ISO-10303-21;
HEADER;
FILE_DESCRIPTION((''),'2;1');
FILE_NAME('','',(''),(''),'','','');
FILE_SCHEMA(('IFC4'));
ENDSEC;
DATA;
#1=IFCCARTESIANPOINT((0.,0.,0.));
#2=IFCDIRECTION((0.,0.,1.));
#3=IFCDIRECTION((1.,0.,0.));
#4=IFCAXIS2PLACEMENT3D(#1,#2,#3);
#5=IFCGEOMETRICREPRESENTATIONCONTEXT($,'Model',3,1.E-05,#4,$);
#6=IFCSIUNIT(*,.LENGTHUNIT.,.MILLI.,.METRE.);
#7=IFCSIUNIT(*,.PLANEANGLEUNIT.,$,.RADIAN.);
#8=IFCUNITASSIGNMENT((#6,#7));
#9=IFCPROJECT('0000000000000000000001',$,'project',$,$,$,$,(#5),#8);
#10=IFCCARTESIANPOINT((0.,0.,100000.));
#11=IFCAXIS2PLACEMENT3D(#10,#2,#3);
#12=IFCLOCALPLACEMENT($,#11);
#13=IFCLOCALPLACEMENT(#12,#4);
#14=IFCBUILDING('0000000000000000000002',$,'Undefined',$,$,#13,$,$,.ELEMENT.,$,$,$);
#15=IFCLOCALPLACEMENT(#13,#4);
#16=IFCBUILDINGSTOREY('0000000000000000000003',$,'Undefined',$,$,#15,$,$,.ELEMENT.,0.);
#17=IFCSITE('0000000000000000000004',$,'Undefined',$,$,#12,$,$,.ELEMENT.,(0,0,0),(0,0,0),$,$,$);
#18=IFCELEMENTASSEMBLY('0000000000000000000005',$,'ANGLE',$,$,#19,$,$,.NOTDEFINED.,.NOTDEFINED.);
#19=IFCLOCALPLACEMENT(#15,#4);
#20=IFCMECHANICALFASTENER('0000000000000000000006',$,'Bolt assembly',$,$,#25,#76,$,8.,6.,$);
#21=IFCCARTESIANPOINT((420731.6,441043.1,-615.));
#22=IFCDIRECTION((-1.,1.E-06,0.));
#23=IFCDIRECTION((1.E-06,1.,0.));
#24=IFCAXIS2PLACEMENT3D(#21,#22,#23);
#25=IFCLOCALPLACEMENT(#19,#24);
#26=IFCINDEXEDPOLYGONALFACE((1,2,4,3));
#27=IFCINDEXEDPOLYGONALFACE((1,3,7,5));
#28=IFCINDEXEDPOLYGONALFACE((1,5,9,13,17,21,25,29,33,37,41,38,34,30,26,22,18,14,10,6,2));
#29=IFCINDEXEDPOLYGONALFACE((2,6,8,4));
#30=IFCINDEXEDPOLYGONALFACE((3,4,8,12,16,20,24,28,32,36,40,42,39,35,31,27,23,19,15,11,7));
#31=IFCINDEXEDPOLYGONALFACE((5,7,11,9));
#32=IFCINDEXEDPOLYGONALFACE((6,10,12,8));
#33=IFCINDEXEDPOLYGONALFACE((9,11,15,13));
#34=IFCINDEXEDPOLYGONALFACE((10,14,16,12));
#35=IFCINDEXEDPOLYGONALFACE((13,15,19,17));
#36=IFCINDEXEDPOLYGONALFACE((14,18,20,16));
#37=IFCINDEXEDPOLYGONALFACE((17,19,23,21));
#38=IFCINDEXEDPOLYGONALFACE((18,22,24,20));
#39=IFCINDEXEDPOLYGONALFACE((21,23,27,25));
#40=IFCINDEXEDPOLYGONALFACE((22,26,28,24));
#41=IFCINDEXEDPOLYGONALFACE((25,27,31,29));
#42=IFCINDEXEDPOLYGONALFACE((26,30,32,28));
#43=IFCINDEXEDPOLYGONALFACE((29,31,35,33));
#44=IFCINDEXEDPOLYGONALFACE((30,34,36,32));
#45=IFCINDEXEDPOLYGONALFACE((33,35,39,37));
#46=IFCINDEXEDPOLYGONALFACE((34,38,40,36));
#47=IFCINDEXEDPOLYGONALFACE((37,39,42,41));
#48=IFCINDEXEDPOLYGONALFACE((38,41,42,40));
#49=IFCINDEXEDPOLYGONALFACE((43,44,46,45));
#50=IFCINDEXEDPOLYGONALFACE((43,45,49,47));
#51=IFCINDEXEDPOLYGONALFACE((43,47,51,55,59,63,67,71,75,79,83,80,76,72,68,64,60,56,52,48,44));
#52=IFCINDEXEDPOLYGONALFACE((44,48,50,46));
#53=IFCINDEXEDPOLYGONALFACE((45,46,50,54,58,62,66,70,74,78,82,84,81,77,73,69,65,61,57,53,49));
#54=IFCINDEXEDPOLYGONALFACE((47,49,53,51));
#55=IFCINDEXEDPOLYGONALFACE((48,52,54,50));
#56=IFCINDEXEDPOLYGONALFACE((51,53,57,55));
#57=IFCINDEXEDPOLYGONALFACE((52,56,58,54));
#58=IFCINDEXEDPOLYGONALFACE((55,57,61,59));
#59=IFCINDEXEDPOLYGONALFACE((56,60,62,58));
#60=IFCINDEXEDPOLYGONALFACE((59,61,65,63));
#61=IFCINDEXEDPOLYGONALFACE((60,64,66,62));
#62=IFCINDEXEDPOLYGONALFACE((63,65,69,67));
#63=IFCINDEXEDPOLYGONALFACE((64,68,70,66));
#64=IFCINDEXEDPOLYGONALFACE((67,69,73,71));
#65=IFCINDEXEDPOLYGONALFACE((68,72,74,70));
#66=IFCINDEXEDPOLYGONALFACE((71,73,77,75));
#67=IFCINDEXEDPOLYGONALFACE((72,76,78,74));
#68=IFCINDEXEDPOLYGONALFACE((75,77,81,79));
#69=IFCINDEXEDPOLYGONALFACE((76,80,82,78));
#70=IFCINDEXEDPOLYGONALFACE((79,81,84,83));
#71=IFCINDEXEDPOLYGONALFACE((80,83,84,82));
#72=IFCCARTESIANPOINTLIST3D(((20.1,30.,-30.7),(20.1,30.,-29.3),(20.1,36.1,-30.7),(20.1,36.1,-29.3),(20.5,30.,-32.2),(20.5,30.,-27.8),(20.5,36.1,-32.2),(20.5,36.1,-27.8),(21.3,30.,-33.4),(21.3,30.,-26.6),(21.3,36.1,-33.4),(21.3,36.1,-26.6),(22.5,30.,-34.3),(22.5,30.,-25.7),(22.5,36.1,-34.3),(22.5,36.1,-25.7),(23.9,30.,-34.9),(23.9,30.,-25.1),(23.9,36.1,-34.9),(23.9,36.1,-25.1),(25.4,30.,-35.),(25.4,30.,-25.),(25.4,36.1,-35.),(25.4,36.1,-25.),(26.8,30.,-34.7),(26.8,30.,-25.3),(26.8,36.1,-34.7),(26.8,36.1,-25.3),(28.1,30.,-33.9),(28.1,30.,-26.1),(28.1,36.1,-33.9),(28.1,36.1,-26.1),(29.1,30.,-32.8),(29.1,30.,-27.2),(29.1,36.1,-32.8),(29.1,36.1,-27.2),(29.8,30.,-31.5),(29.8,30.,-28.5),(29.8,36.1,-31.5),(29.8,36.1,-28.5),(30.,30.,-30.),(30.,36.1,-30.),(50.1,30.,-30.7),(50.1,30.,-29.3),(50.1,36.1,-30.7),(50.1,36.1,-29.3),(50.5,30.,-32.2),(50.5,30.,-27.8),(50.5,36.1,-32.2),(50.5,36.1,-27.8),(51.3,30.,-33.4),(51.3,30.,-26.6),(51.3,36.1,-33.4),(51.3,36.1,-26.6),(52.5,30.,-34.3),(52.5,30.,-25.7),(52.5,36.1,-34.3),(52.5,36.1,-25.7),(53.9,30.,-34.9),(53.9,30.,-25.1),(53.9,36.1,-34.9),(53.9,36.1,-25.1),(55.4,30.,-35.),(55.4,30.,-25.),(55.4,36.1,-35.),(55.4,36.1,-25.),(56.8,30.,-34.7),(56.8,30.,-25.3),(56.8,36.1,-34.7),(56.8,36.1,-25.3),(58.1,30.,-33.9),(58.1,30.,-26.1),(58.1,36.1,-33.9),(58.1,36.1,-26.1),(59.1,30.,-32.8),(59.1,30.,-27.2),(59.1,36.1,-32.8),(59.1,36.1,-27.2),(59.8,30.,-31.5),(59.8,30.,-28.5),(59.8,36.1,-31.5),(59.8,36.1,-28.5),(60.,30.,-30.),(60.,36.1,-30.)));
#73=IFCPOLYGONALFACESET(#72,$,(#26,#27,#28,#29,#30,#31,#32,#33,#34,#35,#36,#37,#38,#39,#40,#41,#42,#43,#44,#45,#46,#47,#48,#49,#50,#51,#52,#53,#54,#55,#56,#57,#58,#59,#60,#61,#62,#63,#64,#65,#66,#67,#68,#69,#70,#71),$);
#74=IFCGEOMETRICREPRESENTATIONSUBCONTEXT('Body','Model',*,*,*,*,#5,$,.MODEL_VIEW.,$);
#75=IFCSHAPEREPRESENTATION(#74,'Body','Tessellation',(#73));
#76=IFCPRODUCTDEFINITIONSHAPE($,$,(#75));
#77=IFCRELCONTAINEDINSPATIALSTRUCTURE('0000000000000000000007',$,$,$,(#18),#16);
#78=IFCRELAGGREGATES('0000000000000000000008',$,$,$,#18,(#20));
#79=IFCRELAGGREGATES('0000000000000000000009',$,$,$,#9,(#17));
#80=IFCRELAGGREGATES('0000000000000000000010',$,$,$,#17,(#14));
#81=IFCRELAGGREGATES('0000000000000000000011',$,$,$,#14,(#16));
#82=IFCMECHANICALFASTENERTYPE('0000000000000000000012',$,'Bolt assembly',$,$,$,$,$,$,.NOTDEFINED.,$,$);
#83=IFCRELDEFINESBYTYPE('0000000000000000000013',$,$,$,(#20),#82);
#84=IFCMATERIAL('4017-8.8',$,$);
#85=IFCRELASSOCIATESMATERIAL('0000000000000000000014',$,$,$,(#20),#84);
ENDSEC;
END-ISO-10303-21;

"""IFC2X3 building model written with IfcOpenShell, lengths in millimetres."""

from ifc_helpers import new_model, si_unit, frame, origin_with_axes, origin_2d_with_axis, place, context, subcontext, project, spatial, circle, extrude, source, transform, mapped, material, type_object, element, aggregate, save


model = new_model("IFC2X3")

# Units and contexts
model_context = context("Model", 3, precision=1e-05, world=origin_with_axes())
body_context = subcontext(model_context, "Body", "Model", "MODEL_VIEW")
ifc_project = project(units=[si_unit("LENGTHUNIT", "METRE", prefix="MILLI"), si_unit("PLANEANGLEUNIT", "RADIAN")], contexts=[model_context])

# Site, building, storey
site_placement = place(None, frame((0.0, 0.0, 100000.0), z_axis=(0.0, 0.0, 1.0), x_axis=(1.0, 0.0, 0.0)))
site = spatial("IfcSite", under=ifc_project, at=site_placement, Name="Undefined", CompositionType="ELEMENT", RefLatitude=(0, 0, 0), RefLongitude=(0, 0, 0))
building_placement = place(site_placement, origin_with_axes())
building = spatial("IfcBuilding", under=site, at=building_placement, Name="Undefined", CompositionType="ELEMENT")
storey_placement = place(building_placement, origin_with_axes())
storey = spatial("IfcBuildingStorey", under=building, at=storey_placement, Name="Undefined", CompositionType="ELEMENT", Elevation=0.0)

# Element assembly
assembly_1_placement = place(storey_placement, origin_with_axes())
assembly_1 = element("IfcElementAssembly", 1, at=assembly_1_placement, inside=storey, Name="ANGLE", AssemblyPlace="NOTDEFINED", PredefinedType="NOTDEFINED")

# Mechanical fastener
ifc_material_1 = material(Name="4017-8.8")
mechanical_fastener_type = type_object("IfcMechanicalFastenerType", Name="Bolt assembly")
shared_shape_1 = source(origin_with_axes(), body_context, "Body", "SweptSolid", [
    extrude(circle(Radius=5.0, at=origin_2d_with_axis()), frame((0.0, 30.0, 0.0), z_axis=(0.0, 1.0, 0.0), x_axis=(1.0, 0.0, 0.0)), (0.0, 0.0, 1.0), 6.1),
])
mechanical_fastener_1_placement = place(assembly_1_placement, frame((420731.6, 441043.1, -615.0), z_axis=(-1.0, 0.000001, 0.0), x_axis=(0.000001, 1.0, 0.0)))
mechanical_fastener_1 = element("IfcMechanicalFastener", 2, at=mechanical_fastener_1_placement, type_object=mechanical_fastener_type, material=ifc_material_1, Name="Bolt assembly", NominalDiameter=8.0, NominalLength=6.0, context=body_context, shape_type="MappedRepresentation", body=[
    mapped(shared_shape_1, transform((25.0, 0.0, -30.0))),
    mapped(shared_shape_1, transform((55.0, 0.0, -30.0))),
])
aggregate(assembly_1, [mechanical_fastener_1])

save(model, "model.ifc")
